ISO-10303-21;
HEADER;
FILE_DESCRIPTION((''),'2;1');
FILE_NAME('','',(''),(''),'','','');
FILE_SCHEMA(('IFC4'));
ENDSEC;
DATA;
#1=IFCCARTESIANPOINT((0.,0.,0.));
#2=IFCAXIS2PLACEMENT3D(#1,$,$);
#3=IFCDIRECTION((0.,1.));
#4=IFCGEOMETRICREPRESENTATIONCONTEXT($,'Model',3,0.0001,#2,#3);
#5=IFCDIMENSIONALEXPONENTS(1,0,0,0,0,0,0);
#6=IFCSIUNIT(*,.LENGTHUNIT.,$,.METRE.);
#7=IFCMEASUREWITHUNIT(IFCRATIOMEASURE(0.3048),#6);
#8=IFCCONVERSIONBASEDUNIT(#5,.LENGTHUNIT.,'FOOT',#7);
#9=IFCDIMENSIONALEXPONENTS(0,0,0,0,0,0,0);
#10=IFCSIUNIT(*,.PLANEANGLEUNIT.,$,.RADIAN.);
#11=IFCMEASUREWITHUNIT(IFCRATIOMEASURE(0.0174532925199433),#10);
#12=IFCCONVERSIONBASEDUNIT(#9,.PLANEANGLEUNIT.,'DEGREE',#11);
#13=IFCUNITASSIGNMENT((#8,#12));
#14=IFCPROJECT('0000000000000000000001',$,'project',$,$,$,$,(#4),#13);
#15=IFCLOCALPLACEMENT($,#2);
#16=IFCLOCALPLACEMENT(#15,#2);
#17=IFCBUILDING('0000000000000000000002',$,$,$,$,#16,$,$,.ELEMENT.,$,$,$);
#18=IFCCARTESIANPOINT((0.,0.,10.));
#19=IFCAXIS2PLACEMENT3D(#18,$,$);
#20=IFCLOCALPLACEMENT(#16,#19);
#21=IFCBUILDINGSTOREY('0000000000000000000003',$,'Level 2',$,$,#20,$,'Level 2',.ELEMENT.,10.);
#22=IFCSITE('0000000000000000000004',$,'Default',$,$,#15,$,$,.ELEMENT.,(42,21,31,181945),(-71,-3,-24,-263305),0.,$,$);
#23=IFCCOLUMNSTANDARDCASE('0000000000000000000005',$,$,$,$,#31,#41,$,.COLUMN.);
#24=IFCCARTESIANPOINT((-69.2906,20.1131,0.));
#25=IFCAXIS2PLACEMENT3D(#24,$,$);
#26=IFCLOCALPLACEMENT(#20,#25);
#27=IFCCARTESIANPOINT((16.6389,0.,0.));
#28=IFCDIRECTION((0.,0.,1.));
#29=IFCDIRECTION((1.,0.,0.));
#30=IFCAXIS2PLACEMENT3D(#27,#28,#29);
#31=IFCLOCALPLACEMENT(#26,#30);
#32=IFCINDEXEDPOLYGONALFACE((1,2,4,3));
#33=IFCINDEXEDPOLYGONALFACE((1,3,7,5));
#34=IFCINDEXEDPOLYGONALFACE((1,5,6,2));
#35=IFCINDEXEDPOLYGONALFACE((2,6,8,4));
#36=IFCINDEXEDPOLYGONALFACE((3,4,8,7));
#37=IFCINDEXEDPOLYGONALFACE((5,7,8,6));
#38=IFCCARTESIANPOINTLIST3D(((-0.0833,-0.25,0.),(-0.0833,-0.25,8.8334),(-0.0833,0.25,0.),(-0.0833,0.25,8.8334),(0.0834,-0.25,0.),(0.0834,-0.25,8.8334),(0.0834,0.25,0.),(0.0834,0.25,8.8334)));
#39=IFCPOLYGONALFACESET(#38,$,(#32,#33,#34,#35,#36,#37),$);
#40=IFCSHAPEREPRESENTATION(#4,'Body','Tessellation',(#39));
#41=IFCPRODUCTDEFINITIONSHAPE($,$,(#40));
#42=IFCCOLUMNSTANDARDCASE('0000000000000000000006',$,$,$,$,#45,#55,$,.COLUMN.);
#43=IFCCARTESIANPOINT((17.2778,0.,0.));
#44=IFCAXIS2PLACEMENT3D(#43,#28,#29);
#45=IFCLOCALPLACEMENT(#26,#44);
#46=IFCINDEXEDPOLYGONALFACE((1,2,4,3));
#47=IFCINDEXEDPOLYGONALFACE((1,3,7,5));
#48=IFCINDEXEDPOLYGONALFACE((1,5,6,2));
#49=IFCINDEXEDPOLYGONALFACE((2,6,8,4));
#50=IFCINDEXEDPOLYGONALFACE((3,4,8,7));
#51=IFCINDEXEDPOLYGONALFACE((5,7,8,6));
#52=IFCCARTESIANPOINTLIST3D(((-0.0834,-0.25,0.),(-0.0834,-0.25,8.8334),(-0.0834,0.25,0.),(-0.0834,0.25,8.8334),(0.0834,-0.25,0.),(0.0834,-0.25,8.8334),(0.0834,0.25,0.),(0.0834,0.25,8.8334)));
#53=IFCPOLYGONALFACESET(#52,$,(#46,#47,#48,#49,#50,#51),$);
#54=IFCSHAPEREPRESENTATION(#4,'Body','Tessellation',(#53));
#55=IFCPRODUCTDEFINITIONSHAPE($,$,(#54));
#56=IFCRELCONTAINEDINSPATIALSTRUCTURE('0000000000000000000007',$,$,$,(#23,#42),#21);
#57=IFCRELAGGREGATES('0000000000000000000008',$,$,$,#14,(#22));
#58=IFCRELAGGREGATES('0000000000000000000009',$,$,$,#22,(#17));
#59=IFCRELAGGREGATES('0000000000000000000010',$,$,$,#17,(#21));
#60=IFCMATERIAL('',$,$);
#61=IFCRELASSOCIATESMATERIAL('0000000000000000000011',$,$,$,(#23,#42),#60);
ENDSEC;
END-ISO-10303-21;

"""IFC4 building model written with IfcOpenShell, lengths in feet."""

from ifc_helpers import new_model, entity, si_unit, converted_unit, direction, frame, origin, place, context, project, spatial, rectangle, extrude, material, element, save


model = new_model("IFC4")

# Units and contexts
model_context = context("Model", 3, precision=0.0001, world=origin(), true_north=direction((0.0, 1.0)))
ifc_project = project(units=[converted_unit("LENGTHUNIT", "FOOT", entity("IfcRatioMeasure", 0.3048), si_unit("LENGTHUNIT", "METRE"), dimensions=[1, 0, 0, 0, 0, 0, 0]), converted_unit("PLANEANGLEUNIT", "DEGREE", entity("IfcRatioMeasure", 0.0174532925199433), si_unit("PLANEANGLEUNIT", "RADIAN"), dimensions=[0, 0, 0, 0, 0, 0, 0])], contexts=[model_context])

# Site, building, storey
site_placement = place(None, origin())
site = spatial("IfcSite", under=ifc_project, at=site_placement, Name="Default", CompositionType="ELEMENT", RefLatitude=(42, 21, 31, 181945), RefLongitude=(-71, -3, -24, -263305), RefElevation=0.0)
building_placement = place(site_placement, origin())
building = spatial("IfcBuilding", under=site, at=building_placement, CompositionType="ELEMENT")
storey_placement = place(building_placement, frame((0.0, 0.0, 10.0)))
storey = spatial("IfcBuildingStorey", under=building, at=storey_placement, Name="Level 2", LongName="Level 2", CompositionType="ELEMENT", Elevation=10.0)

# Columns
ifc_material_1 = material(Name="")
placement_1 = place(storey_placement, frame((-69.2906, 20.1131, 0.0)))
for number, where, z_axis, x_axis in (
    (1, (16.6389, 0.0, 0.0), (0.0, 0.0, 1.0), (1.0, 0.0, 0.0)),
    (2, (17.2778, 0.0, 0.0), (0.0, 0.0, 1.0), (1.0, 0.0, 0.0)),
):
    element("IfcColumnStandardCase", number, at=place(placement_1, frame(where, z_axis=z_axis, x_axis=x_axis)), inside=storey, material=ifc_material_1, PredefinedType="COLUMN", context=model_context, shape_type="SweptSolid", body=[
        extrude(rectangle(XDim=0.1667, YDim=0.5), origin(), (0.0, 0.0, 1.0), 8.8334),
    ])

save(model, "model.ifc")
